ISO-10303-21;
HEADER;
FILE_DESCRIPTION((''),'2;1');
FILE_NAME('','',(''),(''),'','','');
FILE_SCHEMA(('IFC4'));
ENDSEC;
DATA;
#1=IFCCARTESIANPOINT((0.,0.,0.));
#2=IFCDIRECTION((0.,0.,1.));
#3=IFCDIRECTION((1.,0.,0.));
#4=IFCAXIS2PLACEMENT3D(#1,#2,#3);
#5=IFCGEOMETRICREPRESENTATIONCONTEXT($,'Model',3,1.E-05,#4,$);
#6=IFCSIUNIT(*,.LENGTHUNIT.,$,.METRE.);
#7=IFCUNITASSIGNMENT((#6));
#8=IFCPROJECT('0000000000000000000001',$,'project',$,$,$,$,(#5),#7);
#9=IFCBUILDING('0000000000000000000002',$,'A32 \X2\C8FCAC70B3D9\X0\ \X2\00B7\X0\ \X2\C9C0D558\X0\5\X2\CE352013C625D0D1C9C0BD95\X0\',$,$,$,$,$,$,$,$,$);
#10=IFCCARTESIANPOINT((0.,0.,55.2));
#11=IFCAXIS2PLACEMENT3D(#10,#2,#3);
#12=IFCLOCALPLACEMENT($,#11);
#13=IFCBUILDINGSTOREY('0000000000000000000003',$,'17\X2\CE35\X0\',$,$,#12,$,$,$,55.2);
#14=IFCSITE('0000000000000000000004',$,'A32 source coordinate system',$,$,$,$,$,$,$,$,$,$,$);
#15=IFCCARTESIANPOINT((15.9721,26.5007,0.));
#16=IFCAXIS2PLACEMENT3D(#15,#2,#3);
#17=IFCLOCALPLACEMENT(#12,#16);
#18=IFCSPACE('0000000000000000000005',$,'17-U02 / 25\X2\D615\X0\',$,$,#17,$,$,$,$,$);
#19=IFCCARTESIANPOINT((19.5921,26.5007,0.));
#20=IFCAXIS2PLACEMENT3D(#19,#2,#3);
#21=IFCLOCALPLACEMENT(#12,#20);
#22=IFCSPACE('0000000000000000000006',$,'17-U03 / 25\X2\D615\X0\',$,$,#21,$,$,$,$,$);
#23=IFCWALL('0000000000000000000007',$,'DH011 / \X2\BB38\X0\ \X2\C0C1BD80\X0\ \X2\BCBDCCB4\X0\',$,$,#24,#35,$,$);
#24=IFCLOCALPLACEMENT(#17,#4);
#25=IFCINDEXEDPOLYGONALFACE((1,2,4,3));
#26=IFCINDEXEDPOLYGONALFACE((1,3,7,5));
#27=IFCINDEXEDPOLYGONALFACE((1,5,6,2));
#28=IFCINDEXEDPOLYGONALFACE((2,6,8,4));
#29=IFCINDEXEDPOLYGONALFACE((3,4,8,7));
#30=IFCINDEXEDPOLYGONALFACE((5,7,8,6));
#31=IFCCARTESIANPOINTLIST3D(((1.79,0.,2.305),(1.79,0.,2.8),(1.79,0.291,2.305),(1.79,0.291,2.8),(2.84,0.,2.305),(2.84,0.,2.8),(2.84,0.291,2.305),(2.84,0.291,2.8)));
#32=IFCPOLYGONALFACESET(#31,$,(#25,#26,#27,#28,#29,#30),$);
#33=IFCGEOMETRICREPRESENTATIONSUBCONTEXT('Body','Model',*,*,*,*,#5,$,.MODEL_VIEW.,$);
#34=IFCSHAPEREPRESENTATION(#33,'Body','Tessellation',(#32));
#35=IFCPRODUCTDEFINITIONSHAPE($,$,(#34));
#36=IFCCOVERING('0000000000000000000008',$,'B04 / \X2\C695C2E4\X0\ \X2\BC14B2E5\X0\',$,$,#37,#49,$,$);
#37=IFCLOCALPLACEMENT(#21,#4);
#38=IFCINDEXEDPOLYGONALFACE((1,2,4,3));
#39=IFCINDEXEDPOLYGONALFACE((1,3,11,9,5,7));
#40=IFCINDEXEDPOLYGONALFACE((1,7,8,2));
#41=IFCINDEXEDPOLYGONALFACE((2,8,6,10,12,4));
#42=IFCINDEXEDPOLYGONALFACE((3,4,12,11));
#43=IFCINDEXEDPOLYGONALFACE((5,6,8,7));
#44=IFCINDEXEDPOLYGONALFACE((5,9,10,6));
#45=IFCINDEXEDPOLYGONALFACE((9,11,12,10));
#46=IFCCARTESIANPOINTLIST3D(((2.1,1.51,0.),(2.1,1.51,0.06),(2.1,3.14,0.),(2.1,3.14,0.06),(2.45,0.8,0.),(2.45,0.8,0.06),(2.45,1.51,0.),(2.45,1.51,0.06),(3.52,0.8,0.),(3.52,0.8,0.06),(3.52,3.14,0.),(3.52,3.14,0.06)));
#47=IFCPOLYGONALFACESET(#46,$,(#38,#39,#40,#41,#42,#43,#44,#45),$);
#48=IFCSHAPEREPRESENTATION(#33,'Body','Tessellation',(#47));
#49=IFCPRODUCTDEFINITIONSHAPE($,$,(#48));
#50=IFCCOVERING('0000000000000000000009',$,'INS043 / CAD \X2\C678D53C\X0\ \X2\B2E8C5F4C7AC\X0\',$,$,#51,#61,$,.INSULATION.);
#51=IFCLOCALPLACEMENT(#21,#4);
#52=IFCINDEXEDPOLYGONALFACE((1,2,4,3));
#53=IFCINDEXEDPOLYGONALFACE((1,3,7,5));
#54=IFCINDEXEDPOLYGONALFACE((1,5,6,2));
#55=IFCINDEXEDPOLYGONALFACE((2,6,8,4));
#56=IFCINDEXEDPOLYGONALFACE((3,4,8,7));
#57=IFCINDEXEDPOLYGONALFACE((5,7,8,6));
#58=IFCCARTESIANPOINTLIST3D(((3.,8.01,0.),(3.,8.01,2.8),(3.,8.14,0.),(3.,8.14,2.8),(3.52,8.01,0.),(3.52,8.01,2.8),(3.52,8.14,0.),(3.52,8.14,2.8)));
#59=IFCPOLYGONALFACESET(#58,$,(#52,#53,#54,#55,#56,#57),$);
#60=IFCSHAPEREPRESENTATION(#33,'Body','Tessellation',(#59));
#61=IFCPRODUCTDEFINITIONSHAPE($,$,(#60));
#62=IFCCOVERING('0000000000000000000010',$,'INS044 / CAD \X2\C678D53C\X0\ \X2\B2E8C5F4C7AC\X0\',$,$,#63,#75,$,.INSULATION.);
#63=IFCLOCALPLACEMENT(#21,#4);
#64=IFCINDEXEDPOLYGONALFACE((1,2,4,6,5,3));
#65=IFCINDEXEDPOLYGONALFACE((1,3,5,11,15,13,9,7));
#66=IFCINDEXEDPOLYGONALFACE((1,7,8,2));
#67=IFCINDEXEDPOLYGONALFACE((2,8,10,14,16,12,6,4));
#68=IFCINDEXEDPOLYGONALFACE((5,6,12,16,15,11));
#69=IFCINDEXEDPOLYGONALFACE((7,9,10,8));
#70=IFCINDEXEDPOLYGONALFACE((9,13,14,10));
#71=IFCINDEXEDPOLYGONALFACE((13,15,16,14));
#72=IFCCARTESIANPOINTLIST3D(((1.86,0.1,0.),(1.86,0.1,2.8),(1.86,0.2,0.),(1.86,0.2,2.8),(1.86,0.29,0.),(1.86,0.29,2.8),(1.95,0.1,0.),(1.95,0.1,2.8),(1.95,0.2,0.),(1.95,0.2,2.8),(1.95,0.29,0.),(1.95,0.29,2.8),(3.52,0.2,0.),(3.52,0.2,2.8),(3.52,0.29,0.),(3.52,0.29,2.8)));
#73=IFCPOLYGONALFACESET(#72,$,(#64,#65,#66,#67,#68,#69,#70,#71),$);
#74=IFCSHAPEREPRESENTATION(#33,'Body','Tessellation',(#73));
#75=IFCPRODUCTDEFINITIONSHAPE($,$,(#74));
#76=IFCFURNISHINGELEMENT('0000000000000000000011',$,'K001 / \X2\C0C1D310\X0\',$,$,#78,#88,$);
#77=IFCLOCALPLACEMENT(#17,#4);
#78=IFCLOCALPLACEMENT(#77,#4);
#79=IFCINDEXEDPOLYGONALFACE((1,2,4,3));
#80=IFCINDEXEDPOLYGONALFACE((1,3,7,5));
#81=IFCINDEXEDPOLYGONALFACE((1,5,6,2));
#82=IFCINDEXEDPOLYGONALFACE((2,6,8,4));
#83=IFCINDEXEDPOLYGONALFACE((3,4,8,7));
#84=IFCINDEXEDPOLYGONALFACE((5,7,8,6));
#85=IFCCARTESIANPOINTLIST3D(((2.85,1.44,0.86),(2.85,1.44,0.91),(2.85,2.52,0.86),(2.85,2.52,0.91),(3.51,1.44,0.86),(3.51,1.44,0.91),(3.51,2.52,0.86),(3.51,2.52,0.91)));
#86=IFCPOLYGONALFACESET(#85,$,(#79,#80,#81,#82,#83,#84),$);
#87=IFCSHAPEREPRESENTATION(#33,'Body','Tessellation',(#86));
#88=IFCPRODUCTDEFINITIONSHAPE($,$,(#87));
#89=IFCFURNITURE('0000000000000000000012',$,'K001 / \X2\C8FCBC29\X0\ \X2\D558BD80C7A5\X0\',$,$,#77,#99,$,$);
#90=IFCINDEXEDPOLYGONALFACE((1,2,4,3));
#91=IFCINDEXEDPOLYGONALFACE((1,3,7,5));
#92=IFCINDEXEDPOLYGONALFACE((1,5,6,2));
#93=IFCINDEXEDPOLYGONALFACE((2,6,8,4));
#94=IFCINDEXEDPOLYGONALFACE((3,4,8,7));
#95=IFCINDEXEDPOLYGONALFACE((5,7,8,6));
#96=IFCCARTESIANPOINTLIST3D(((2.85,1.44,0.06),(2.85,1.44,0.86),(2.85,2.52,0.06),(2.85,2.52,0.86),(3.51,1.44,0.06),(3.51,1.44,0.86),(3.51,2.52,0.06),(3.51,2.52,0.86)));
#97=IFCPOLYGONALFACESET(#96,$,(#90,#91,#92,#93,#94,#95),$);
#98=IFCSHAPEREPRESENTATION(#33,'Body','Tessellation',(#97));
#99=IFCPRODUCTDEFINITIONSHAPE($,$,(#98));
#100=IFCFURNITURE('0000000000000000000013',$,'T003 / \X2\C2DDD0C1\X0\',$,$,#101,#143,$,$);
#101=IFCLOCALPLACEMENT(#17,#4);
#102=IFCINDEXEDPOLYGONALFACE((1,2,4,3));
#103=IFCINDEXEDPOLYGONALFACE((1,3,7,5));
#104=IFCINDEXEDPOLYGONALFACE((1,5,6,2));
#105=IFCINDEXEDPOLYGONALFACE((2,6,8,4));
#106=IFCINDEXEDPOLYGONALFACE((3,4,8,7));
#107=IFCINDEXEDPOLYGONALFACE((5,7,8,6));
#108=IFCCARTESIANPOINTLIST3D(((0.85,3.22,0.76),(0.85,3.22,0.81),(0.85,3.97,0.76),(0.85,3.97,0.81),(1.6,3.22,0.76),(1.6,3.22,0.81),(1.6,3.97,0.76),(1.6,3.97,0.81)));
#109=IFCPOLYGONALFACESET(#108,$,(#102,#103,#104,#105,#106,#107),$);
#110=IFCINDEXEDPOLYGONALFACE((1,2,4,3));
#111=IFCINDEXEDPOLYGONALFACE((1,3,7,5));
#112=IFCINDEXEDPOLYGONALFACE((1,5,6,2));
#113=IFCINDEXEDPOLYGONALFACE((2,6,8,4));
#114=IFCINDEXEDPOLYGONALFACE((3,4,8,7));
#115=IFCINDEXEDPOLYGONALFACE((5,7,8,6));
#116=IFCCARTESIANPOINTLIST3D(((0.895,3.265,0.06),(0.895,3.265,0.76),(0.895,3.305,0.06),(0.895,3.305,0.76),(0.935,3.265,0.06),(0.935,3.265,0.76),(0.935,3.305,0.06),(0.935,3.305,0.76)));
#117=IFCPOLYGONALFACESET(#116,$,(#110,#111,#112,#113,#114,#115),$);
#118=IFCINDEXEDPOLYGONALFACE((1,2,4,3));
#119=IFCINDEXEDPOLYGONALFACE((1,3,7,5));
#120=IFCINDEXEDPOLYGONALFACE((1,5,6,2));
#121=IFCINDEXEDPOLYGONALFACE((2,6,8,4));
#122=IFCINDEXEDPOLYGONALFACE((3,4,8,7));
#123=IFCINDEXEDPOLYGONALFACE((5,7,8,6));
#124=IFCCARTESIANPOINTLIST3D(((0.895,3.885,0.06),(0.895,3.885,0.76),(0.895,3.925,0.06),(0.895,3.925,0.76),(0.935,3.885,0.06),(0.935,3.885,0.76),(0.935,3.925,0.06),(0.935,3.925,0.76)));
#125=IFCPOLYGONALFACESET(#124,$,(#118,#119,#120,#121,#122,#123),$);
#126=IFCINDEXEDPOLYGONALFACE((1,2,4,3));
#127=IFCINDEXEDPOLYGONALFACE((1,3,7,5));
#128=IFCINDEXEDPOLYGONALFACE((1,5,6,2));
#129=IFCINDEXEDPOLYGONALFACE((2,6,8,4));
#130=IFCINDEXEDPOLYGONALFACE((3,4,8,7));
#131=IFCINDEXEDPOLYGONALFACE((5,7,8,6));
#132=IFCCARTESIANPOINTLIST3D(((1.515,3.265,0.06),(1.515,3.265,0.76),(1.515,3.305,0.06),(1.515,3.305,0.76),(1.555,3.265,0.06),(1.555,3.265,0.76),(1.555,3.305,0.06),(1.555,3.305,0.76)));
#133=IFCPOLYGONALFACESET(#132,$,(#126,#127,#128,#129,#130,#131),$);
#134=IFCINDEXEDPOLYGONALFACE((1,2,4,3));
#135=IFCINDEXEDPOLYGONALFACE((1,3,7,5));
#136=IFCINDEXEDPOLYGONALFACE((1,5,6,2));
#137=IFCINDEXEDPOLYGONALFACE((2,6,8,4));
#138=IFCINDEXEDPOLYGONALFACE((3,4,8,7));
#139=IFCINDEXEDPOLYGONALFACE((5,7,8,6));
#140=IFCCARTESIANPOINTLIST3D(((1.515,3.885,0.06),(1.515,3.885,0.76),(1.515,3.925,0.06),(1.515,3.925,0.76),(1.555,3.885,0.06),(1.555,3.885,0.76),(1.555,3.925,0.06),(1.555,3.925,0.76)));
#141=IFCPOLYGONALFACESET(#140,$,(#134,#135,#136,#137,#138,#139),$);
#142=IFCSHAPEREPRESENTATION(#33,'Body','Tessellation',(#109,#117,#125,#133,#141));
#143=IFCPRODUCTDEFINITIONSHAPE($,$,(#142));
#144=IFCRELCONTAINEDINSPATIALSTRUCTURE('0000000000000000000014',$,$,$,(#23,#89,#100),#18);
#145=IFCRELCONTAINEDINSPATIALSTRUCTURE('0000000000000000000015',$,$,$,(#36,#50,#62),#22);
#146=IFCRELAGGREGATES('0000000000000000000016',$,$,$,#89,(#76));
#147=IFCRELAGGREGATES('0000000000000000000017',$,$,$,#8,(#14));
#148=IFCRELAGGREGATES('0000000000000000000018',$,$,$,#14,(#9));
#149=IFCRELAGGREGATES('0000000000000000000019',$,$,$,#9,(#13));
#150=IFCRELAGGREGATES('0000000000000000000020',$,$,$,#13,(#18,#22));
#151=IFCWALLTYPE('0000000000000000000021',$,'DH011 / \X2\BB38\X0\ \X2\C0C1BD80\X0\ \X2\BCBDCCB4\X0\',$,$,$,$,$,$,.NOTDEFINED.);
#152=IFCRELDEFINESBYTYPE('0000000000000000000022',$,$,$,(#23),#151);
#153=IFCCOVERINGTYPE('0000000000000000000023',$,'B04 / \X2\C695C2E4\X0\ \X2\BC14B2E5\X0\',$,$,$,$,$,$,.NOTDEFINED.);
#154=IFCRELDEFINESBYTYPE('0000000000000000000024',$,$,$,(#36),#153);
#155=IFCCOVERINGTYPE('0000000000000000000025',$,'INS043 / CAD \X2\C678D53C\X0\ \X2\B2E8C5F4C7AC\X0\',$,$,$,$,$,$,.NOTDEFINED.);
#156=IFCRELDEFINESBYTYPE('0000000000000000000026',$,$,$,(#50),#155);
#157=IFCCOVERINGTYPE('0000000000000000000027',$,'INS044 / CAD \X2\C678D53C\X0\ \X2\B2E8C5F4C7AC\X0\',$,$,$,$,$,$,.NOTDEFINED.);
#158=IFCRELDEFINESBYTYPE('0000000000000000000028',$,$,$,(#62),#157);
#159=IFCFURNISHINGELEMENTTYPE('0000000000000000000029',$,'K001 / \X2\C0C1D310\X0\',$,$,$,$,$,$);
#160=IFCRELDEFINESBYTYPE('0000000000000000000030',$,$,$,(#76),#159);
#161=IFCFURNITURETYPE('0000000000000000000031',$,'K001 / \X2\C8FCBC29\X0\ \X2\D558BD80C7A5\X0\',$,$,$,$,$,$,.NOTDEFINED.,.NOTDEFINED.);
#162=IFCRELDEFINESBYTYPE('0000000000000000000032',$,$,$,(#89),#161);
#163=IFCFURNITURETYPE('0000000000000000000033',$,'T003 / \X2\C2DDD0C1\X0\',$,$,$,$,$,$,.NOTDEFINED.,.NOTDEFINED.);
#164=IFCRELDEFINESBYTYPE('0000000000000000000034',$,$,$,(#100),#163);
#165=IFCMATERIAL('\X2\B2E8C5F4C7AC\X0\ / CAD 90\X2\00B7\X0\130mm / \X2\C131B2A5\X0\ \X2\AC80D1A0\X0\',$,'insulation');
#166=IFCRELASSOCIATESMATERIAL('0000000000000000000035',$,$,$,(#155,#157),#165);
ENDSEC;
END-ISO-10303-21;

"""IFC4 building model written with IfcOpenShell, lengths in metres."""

from ifc_helpers import new_model, si_unit, frame, origin, origin_with_axes, place, context, subcontext, project, spatial, polyline, outline, extrude, source, transform, mapped, material, type_object, type_shapes, element, aggregate, save


model = new_model("IFC4")

# Units and contexts
model_context = context("Model", 3, precision=1e-05, world=origin_with_axes())
body_context = subcontext(model_context, "Body", "Model", "MODEL_VIEW")
ifc_project = project(units=[si_unit("LENGTHUNIT", "METRE")], contexts=[model_context])

# Site, building, storey, space
site = spatial("IfcSite", under=ifc_project, Name="A32 source coordinate system")
building = spatial("IfcBuilding", under=site, Name="A32 주거동 · 지하5층–옥탑지붕")
storey_placement = place(None, frame((0.0, 0.0, 55.2), z_axis=(0.0, 0.0, 1.0), x_axis=(1.0, 0.0, 0.0)))
storey = spatial("IfcBuildingStorey", under=building, at=storey_placement, Name="17층", Elevation=55.2)
space_1_placement = place(storey_placement, frame((15.9721, 26.5007, 0.0), z_axis=(0.0, 0.0, 1.0), x_axis=(1.0, 0.0, 0.0)))
space_1 = spatial("IfcSpace", under=storey, at=space_1_placement, Name="17-U02 / 25형")

# Wall
wall_type_1 = type_object("IfcWallType", Name="DH011 / 문 상부 벽체", PredefinedType="NOTDEFINED")
shared_shape_1 = source(origin(), body_context, "Body", "SweptSolid", [
    extrude(outline(polyline([(2.84, 0.0), (1.79, 0.0), (1.79, 0.291), (2.84, 0.291), (2.84, 0.0)])), frame((0.0, 0.0, 2.305)), (0.0, 0.0, 1.0), 0.495),
])
type_shapes(wall_type_1, [shared_shape_1])
wall_1_placement = place(space_1_placement, origin_with_axes())
element("IfcWall", 1, at=wall_1_placement, inside=space_1, type_object=wall_type_1, Name="DH011 / 문 상부 벽체", context=body_context, shape_type="MappedRepresentation", body=[
    mapped(shared_shape_1, transform((0.0, 0.0, 0.0), scale=1.0)),
])

# Shared definitions
space_2_placement = place(storey_placement, frame((19.5921, 26.5007, 0.0), z_axis=(0.0, 0.0, 1.0), x_axis=(1.0, 0.0, 0.0)))
space_2 = spatial("IfcSpace", under=storey, at=space_2_placement, Name="17-U03 / 25형")

# Coverings
covering_type_1 = type_object("IfcCoveringType", Name="B04 / 욕실 바닥", PredefinedType="NOTDEFINED")
shared_shape_2 = source(origin(), body_context, "Body", "SweptSolid", [
    extrude(outline(polyline([(2.1, 1.51), (2.1, 3.14), (3.52, 3.14), (3.52, 0.8), (2.45, 0.8), (2.45, 1.51), (2.1, 1.51)])), origin(), (0.0, 0.0, 1.0), 0.06),
])
type_shapes(covering_type_1, [shared_shape_2])
covering_1_placement = place(space_2_placement, origin_with_axes())
element("IfcCovering", 2, at=covering_1_placement, inside=space_2, type_object=covering_type_1, Name="B04 / 욕실 바닥", context=body_context, shape_type="MappedRepresentation", body=[
    mapped(shared_shape_2, transform((0.0, 0.0, 0.0), scale=1.0)),
])
ifc_material = material(Name="단열재 / CAD 90·130mm / 성능 검토", Category="insulation")
covering_type_2 = type_object("IfcCoveringType", Name="INS043 / CAD 외피 단열재", PredefinedType="NOTDEFINED", material=ifc_material)
shared_shape_3 = source(origin(), body_context, "Body", "SweptSolid", [
    extrude(outline(polyline([(3.52, 8.14), (3.52, 8.01), (3.0, 8.01), (3.0, 8.14), (3.52, 8.14)])), origin(), (0.0, 0.0, 1.0), 2.8),
])
type_shapes(covering_type_2, [shared_shape_3])
covering_2_placement = place(space_2_placement, origin_with_axes())
element("IfcCovering", 3, at=covering_2_placement, inside=space_2, type_object=covering_type_2, Name="INS043 / CAD 외피 단열재", PredefinedType="INSULATION", context=body_context, shape_type="MappedRepresentation", body=[
    mapped(shared_shape_3, transform((0.0, 0.0, 0.0), scale=1.0)),
])
covering_type_3 = type_object("IfcCoveringType", Name="INS044 / CAD 외피 단열재", PredefinedType="NOTDEFINED", material=ifc_material)
shared_shape_4 = source(origin(), body_context, "Body", "SweptSolid", [
    extrude(outline(polyline([(1.86, 0.2), (1.86, 0.29), (1.95, 0.29), (3.52, 0.29), (3.52, 0.2), (1.95, 0.2), (1.95, 0.1), (1.86, 0.1), (1.86, 0.2)])), origin(), (0.0, 0.0, 1.0), 2.8),
])
type_shapes(covering_type_3, [shared_shape_4])
covering_3_placement = place(space_2_placement, origin_with_axes())
element("IfcCovering", 4, at=covering_3_placement, inside=space_2, type_object=covering_type_3, Name="INS044 / CAD 외피 단열재", PredefinedType="INSULATION", context=body_context, shape_type="MappedRepresentation", body=[
    mapped(shared_shape_4, transform((0.0, 0.0, 0.0), scale=1.0)),
])

# Furnishing element
furnishing_element_type_1 = type_object("IfcFurnishingElementType", Name="K001 / 상판")
shared_shape_5 = source(origin(), body_context, "Body", "SweptSolid", [
    extrude(outline(polyline([(2.85, 2.52), (3.51, 2.52), (3.51, 1.44), (2.85, 1.44), (2.85, 2.52)])), frame((0.0, 0.0, 0.86)), (0.0, 0.0, 1.0), 0.05),
])
type_shapes(furnishing_element_type_1, [shared_shape_5])
furniture_1_placement = place(space_1_placement, origin_with_axes())
furnishing_1_placement = place(furniture_1_placement, origin_with_axes())
furnishing_1 = element("IfcFurnishingElement", 5, at=furnishing_1_placement, type_object=furnishing_element_type_1, Name="K001 / 상판", context=body_context, shape_type="MappedRepresentation", body=[
    mapped(shared_shape_5, transform((0.0, 0.0, 0.0), scale=1.0)),
])

# Furniture
furniture_type_1 = type_object("IfcFurnitureType", Name="K001 / 주방 하부장", AssemblyPlace="NOTDEFINED", PredefinedType="NOTDEFINED")
shared_shape_6 = source(origin(), body_context, "Body", "SweptSolid", [
    extrude(outline(polyline([(2.85, 1.44), (2.85, 2.52), (3.51, 2.52), (3.51, 1.44), (2.85, 1.44)])), frame((0.0, 0.0, 0.06)), (0.0, 0.0, 1.0), 0.8),
])
type_shapes(furniture_type_1, [shared_shape_6])
furniture_1 = element("IfcFurniture", 6, at=furniture_1_placement, inside=space_1, type_object=furniture_type_1, Name="K001 / 주방 하부장", context=body_context, shape_type="MappedRepresentation", body=[
    mapped(shared_shape_6, transform((0.0, 0.0, 0.0), scale=1.0)),
])
aggregate(furniture_1, [furnishing_1])
furniture_type_2 = type_object("IfcFurnitureType", Name="T003 / 식탁", AssemblyPlace="NOTDEFINED", PredefinedType="NOTDEFINED")
shared_shape_7 = source(origin(), body_context, "Body", "SweptSolid", [
    extrude(outline(polyline([(1.6, 3.97), (1.6, 3.22), (0.85, 3.22), (0.85, 3.97), (1.6, 3.97)])), frame((0.0, 0.0, 0.76)), (0.0, 0.0, 1.0), 0.05),
    extrude(outline(polyline([(0.895, 3.265), (0.895, 3.305), (0.935, 3.305), (0.935, 3.265), (0.895, 3.265)])), frame((0.0, 0.0, 0.06)), (0.0, 0.0, 1.0), 0.7),
    extrude(outline(polyline([(0.895, 3.885), (0.895, 3.925), (0.935, 3.925), (0.935, 3.885), (0.895, 3.885)])), frame((0.0, 0.0, 0.06)), (0.0, 0.0, 1.0), 0.7),
    extrude(outline(polyline([(1.515, 3.265), (1.515, 3.305), (1.555, 3.305), (1.555, 3.265), (1.515, 3.265)])), frame((0.0, 0.0, 0.06)), (0.0, 0.0, 1.0), 0.7),
    extrude(outline(polyline([(1.515, 3.885), (1.515, 3.925), (1.555, 3.925), (1.555, 3.885), (1.515, 3.885)])), frame((0.0, 0.0, 0.06)), (0.0, 0.0, 1.0), 0.7),
])
type_shapes(furniture_type_2, [shared_shape_7])
furniture_2_placement = place(space_1_placement, origin_with_axes())
element("IfcFurniture", 7, at=furniture_2_placement, inside=space_1, type_object=furniture_type_2, Name="T003 / 식탁", context=body_context, shape_type="MappedRepresentation", body=[
    mapped(shared_shape_7, transform((0.0, 0.0, 0.0), scale=1.0)),
])

save(model, "model.ifc")
